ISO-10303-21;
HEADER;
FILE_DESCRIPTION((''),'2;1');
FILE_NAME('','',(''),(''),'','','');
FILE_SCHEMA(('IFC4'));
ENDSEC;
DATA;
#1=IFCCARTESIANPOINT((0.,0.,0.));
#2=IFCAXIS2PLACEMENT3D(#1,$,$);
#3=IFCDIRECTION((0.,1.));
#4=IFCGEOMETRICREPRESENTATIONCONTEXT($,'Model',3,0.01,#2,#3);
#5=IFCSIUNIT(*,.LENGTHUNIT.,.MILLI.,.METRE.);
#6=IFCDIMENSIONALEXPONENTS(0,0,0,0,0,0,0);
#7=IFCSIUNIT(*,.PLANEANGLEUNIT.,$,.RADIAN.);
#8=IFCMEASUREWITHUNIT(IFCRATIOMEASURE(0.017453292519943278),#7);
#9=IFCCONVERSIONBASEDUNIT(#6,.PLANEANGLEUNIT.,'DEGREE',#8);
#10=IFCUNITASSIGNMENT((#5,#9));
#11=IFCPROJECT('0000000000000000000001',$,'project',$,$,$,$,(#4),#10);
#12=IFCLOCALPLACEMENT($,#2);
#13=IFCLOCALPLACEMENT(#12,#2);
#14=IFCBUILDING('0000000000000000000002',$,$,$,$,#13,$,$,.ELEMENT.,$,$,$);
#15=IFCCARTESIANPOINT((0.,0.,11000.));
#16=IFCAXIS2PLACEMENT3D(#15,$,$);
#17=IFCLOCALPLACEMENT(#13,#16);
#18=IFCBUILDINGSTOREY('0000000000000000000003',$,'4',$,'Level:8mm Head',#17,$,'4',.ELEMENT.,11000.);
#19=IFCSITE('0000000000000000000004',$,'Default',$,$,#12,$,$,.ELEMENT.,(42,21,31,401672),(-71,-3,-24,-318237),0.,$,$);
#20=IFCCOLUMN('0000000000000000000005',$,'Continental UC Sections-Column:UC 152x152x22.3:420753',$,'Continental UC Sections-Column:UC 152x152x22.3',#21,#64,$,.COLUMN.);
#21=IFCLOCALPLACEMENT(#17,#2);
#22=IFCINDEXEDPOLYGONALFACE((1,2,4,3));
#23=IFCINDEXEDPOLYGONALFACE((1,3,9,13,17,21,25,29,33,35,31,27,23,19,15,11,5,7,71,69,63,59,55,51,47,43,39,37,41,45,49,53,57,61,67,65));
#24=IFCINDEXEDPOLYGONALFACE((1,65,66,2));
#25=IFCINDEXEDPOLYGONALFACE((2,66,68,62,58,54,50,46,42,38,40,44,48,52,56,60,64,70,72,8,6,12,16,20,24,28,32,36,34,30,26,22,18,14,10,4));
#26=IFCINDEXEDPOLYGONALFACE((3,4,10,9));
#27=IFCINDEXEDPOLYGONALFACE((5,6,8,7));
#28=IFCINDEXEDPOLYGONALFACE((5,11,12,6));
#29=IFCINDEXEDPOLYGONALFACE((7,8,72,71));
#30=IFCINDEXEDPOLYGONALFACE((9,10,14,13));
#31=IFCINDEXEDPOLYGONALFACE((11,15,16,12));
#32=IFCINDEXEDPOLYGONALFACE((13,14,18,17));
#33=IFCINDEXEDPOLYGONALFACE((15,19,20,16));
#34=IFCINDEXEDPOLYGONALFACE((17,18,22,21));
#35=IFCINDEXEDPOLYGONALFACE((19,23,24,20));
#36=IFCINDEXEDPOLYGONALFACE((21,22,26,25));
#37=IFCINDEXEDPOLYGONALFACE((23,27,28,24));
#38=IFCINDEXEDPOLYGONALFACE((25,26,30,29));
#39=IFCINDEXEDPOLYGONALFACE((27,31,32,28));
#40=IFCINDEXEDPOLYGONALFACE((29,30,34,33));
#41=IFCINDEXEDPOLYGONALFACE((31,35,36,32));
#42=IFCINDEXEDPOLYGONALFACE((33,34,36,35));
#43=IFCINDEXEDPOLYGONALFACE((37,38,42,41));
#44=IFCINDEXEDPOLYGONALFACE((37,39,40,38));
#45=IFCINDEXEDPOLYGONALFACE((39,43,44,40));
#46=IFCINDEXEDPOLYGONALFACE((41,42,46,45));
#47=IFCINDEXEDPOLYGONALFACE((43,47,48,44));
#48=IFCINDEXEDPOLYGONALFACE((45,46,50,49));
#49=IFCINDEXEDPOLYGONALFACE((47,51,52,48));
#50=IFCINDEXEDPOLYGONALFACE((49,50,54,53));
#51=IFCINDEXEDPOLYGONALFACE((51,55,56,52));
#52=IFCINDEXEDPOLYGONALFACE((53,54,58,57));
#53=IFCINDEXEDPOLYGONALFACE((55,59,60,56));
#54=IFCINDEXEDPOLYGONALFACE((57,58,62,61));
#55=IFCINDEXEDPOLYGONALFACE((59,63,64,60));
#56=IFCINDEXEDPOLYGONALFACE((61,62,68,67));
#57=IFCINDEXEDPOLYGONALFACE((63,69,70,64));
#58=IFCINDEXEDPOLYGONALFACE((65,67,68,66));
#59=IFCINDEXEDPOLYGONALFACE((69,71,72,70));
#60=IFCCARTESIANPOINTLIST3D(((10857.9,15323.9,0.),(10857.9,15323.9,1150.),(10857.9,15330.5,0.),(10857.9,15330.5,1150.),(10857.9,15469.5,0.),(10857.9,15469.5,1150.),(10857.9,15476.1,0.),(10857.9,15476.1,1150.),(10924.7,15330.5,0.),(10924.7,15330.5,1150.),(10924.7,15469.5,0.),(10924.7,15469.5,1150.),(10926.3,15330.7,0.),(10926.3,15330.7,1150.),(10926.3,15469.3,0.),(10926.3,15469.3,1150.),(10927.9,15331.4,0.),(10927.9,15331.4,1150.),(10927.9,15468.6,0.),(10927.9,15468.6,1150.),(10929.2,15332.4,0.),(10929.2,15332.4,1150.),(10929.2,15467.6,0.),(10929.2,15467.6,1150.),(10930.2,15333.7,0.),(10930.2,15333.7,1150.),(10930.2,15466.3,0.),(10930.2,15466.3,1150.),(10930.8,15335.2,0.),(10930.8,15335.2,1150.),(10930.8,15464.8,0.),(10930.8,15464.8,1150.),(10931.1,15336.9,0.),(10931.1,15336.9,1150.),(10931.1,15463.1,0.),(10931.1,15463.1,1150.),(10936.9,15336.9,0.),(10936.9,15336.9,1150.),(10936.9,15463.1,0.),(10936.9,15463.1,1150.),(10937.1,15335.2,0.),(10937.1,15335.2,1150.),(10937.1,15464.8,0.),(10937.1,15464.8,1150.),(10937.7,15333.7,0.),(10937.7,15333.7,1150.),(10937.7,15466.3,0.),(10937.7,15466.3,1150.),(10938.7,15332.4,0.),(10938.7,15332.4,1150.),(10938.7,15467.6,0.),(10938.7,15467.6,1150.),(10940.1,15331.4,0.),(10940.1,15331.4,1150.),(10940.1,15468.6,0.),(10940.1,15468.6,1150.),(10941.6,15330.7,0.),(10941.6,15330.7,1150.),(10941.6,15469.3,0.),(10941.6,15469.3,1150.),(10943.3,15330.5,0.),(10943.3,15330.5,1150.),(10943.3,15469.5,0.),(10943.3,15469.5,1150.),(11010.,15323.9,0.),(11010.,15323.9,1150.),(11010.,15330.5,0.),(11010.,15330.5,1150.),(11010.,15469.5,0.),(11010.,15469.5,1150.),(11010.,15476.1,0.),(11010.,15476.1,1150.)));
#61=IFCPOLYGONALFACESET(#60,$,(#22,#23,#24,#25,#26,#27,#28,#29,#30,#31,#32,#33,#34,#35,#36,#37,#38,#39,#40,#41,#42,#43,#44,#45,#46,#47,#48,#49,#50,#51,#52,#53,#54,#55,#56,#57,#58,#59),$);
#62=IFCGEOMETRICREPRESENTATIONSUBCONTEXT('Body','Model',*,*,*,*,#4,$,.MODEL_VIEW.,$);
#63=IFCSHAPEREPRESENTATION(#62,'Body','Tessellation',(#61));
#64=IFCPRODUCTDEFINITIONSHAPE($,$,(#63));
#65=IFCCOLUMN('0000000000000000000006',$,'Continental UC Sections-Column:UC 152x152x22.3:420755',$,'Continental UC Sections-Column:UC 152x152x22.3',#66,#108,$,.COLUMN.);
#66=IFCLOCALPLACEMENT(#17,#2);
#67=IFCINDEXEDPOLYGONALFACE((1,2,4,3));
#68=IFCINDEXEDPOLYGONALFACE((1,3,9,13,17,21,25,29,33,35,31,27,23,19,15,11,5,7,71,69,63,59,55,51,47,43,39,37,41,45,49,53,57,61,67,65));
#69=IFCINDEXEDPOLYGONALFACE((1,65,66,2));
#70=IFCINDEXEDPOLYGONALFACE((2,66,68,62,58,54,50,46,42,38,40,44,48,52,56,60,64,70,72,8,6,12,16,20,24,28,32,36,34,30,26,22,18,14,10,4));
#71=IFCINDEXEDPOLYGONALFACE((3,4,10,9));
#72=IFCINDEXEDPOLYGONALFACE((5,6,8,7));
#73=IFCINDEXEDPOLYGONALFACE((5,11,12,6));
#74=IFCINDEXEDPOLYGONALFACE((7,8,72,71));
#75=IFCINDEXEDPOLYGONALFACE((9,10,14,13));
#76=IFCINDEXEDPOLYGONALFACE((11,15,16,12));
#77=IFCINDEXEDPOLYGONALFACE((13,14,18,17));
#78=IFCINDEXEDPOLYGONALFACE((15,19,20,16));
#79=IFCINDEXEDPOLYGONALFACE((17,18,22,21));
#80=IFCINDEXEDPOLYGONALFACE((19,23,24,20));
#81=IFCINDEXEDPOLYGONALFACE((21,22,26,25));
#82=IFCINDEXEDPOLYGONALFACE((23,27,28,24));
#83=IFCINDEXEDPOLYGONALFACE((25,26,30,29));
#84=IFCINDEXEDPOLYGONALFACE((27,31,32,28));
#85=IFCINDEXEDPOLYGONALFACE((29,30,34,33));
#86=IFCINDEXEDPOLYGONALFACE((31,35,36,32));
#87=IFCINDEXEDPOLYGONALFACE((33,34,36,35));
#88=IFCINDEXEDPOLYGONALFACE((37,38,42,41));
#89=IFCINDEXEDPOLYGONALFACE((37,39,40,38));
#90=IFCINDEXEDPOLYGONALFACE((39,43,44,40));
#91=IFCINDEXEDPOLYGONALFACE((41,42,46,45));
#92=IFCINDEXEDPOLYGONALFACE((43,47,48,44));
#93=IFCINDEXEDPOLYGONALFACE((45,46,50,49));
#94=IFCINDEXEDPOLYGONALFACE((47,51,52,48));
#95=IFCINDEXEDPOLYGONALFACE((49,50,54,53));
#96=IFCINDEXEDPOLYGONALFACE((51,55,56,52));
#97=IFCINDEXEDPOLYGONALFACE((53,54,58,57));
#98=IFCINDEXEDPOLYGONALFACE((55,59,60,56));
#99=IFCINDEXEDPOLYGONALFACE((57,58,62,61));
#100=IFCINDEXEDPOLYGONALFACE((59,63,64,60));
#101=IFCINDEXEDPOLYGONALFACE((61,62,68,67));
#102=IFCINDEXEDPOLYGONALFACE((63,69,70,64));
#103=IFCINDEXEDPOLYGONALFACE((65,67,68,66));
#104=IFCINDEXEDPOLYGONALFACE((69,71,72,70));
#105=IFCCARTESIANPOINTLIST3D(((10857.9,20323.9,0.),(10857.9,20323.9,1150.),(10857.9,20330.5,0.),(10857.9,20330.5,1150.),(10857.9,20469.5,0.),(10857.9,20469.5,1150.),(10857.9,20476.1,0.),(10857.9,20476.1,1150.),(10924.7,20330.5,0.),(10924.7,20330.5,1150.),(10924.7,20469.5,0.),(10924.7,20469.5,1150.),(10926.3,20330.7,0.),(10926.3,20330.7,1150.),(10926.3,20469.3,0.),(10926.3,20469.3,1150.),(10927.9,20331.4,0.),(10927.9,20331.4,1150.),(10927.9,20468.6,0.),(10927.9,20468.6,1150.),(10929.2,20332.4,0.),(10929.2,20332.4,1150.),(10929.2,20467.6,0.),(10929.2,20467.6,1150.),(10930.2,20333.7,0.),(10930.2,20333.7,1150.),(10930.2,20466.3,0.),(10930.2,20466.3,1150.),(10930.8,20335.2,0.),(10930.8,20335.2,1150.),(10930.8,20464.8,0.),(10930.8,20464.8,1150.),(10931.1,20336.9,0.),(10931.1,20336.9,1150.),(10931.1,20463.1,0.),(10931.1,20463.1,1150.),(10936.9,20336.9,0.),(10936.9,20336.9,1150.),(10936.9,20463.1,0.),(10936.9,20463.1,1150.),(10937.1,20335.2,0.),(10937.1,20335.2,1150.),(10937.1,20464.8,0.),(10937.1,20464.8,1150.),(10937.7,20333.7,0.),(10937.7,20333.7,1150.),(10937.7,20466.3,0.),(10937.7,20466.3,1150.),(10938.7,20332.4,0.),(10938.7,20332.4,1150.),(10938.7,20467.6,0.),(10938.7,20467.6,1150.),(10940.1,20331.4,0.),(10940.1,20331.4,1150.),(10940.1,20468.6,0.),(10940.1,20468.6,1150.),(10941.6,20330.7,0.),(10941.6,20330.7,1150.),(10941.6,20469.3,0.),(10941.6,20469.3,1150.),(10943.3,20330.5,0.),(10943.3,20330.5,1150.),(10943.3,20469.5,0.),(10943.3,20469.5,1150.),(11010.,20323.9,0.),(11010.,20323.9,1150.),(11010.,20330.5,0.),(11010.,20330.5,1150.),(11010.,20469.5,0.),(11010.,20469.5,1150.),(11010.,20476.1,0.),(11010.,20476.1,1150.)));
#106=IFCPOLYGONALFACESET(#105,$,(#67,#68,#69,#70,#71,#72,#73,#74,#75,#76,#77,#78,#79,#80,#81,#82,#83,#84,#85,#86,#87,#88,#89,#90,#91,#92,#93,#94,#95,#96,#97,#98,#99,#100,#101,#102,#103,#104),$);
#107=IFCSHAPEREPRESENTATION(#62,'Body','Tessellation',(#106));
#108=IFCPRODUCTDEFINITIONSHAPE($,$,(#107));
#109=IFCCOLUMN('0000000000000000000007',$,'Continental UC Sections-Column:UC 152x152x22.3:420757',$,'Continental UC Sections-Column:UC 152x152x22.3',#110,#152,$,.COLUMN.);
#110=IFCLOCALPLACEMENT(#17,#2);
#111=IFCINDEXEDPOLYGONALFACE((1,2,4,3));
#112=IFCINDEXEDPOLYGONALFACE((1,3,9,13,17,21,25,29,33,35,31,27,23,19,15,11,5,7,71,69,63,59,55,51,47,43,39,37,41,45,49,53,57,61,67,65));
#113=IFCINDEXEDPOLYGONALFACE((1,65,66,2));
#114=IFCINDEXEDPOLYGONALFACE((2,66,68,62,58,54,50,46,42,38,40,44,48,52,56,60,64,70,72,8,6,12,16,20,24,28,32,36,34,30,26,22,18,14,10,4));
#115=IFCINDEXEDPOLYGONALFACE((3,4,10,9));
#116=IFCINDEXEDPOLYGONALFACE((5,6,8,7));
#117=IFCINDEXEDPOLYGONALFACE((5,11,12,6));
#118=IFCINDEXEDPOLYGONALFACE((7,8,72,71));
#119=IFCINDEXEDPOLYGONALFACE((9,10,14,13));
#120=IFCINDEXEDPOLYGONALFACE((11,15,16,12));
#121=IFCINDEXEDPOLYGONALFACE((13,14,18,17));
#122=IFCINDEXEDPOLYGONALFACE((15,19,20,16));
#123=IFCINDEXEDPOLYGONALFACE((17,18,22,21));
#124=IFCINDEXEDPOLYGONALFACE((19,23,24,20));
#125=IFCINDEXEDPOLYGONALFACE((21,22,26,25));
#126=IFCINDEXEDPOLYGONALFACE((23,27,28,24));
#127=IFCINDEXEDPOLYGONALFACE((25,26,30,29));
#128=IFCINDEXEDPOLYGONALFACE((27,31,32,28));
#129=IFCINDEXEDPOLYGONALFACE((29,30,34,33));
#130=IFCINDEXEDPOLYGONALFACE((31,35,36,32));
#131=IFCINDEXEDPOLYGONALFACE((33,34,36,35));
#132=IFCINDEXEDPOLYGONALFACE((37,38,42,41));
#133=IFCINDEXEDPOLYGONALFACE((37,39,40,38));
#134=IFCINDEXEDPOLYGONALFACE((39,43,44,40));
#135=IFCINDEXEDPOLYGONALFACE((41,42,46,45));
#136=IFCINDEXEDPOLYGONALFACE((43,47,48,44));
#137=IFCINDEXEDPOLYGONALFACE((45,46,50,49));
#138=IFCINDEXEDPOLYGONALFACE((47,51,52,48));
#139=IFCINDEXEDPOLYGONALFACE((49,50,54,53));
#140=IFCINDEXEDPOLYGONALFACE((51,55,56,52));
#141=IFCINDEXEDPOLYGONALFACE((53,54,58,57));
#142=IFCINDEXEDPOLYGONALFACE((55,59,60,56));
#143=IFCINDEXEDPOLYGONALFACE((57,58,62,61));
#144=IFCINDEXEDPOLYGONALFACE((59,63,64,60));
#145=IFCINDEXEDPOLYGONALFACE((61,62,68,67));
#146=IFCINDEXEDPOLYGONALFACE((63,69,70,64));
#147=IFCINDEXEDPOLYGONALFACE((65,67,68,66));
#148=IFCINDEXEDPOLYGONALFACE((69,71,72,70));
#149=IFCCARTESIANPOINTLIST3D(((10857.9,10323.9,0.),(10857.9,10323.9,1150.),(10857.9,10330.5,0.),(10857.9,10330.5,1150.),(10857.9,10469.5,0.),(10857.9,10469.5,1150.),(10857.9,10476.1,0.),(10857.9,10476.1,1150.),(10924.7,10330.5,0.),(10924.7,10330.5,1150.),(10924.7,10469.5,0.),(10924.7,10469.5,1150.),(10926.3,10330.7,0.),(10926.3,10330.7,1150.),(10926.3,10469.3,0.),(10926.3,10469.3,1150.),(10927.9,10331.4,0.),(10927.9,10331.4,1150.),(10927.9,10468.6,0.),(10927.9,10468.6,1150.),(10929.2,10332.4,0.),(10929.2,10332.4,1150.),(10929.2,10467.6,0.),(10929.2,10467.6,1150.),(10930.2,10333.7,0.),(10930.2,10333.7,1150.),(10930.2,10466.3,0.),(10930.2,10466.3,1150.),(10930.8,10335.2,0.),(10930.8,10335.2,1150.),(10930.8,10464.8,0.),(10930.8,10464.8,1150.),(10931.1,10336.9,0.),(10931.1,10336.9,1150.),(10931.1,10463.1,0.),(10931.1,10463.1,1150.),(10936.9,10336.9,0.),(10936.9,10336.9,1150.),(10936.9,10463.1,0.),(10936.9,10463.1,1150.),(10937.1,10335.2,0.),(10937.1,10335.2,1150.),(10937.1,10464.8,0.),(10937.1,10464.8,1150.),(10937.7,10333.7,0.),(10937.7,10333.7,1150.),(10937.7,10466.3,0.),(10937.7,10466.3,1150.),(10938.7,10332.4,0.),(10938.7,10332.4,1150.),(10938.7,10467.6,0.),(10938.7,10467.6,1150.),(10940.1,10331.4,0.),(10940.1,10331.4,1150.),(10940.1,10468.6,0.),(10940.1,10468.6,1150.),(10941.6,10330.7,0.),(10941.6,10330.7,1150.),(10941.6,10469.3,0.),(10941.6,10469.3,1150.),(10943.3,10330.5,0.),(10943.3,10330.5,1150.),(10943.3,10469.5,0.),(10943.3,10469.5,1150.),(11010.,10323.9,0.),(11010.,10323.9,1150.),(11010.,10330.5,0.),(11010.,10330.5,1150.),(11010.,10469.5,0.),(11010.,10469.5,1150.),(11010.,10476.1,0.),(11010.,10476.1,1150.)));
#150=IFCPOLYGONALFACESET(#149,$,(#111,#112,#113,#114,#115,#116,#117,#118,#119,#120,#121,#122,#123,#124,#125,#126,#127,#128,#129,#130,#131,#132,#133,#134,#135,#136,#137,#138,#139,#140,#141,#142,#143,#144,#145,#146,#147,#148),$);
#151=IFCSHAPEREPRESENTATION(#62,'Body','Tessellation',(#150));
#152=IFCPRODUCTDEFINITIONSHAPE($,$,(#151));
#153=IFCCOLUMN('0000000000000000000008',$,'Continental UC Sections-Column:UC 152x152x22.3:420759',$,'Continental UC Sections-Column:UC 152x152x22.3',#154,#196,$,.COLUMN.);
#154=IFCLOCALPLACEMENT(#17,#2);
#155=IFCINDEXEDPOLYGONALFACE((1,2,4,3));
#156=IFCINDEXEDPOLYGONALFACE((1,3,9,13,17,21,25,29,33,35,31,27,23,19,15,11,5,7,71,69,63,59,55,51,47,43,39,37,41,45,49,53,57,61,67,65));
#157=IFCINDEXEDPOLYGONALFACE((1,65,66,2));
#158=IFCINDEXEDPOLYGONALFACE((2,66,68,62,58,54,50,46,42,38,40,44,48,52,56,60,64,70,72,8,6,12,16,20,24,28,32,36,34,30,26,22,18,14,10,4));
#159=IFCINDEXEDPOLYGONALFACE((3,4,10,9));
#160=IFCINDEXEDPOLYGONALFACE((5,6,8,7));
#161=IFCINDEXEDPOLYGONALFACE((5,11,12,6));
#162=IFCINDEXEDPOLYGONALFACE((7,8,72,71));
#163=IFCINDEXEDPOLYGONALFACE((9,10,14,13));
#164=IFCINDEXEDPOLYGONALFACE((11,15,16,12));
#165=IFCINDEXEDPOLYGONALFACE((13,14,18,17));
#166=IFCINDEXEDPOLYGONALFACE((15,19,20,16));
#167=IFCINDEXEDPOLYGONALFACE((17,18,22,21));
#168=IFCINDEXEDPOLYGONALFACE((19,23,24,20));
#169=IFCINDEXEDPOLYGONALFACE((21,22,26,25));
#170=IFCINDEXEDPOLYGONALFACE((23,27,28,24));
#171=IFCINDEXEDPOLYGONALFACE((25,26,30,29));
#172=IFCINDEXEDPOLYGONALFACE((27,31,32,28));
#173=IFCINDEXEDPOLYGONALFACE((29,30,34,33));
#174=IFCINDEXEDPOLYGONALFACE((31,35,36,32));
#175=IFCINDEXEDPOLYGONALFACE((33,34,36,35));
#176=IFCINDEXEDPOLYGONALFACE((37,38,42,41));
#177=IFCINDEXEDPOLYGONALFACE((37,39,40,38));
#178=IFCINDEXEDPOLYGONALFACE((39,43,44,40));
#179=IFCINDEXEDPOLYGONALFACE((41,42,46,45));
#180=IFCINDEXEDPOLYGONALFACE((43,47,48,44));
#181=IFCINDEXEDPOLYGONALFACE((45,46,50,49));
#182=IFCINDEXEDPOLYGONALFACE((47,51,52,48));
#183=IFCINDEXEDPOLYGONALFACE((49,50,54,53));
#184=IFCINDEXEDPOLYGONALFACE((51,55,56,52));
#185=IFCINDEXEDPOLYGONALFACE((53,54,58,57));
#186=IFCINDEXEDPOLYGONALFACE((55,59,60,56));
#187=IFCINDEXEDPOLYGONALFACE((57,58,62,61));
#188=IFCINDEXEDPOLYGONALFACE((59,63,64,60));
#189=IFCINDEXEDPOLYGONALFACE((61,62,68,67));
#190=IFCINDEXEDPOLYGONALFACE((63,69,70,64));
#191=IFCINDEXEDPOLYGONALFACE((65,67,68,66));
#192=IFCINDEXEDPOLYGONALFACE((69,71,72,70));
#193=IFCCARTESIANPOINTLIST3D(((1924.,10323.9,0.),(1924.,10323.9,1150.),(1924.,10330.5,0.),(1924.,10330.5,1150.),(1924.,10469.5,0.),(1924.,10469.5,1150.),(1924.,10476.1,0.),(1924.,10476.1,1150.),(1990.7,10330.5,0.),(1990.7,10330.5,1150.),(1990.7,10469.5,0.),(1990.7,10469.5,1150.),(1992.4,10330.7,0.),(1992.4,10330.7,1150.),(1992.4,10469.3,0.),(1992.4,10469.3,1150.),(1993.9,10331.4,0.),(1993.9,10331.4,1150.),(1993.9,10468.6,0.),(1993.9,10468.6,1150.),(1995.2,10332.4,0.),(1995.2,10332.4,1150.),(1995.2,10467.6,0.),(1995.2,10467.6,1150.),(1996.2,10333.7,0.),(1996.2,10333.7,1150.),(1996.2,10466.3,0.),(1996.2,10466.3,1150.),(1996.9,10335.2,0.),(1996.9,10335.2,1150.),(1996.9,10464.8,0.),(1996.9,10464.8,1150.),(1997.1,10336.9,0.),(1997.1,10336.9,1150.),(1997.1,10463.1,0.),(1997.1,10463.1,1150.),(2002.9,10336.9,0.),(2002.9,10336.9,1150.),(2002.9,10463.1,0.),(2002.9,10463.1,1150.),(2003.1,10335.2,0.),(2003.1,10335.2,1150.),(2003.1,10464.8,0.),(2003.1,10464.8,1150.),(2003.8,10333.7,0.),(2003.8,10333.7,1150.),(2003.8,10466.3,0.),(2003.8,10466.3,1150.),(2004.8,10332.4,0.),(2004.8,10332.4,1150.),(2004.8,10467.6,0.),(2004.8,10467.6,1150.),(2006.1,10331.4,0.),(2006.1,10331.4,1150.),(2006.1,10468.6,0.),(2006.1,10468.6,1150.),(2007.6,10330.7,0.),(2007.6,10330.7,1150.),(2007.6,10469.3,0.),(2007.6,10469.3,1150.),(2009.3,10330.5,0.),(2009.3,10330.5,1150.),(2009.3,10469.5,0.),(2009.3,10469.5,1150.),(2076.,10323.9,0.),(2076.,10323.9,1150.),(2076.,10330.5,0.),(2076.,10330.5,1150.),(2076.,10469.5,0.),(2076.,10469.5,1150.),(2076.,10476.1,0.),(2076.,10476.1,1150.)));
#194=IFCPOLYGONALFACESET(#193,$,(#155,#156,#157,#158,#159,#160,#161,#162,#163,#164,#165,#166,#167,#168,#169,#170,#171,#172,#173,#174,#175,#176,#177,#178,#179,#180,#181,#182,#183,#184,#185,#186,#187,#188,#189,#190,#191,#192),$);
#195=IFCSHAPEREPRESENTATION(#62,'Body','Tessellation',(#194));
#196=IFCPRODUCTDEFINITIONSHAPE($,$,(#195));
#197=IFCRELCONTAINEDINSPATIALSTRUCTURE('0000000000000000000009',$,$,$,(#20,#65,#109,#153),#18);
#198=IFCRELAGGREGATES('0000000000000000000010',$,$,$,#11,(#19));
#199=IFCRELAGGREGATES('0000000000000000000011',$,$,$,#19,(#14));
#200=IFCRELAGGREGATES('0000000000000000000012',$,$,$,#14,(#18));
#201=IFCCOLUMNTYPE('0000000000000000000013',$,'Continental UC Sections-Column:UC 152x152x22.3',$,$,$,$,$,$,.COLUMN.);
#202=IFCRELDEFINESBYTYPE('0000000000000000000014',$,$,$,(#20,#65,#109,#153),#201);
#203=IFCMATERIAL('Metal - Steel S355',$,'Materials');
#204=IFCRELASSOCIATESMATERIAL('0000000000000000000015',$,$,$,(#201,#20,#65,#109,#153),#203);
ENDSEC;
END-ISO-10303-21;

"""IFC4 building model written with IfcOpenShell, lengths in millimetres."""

from ifc_helpers import new_model, entity, si_unit, converted_unit, direction, frame, origin, place, context, subcontext, project, spatial, line, arc, indexed_curve, outline, extrude, source, transform, mapped, material, type_object, type_shapes, element, save


model = new_model("IFC4")

# Units and contexts
model_context = context("Model", 3, precision=0.01, world=origin(), true_north=direction((0.0, 1.0)))
body_context = subcontext(model_context, "Body", "Model", "MODEL_VIEW")
ifc_project = project(units=[si_unit("LENGTHUNIT", "METRE", prefix="MILLI"), converted_unit("PLANEANGLEUNIT", "DEGREE", entity("IfcRatioMeasure", 0.017453292519943278), si_unit("PLANEANGLEUNIT", "RADIAN"), dimensions=[0, 0, 0, 0, 0, 0, 0])], contexts=[model_context])

# Site, building, storey
site_placement = place(None, origin())
site = spatial("IfcSite", under=ifc_project, at=site_placement, Name="Default", CompositionType="ELEMENT", RefLatitude=(42, 21, 31, 401672), RefLongitude=(-71, -3, -24, -318237), RefElevation=0.0)
building_placement = place(site_placement, origin())
building = spatial("IfcBuilding", under=site, at=building_placement, CompositionType="ELEMENT")
storey_placement = place(building_placement, frame((0.0, 0.0, 11000.0)))
storey = spatial("IfcBuildingStorey", under=building, at=storey_placement, Name="4", ObjectType="Level:8mm Head", LongName="4", CompositionType="ELEMENT", Elevation=11000.0)

# Columns
ifc_material_1 = material(Name="Metal - Steel S355", Category="Materials")
column_type_1 = type_object("IfcColumnType", Name="Continental UC Sections-Column:UC 152x152x22.3", PredefinedType="COLUMN", material=ifc_material_1)
shared_shape_1 = source(origin(), body_context, "Body", "SweptSolid", [
    extrude(outline(indexed_curve([(69.5, -76.0), (76.1, -76.0), (76.1, 76.0), (69.5, 76.0), (69.5, 9.3), (67.6, 4.8), (63.1, 2.9), (-63.1, 2.9), (-67.6, 4.8), (-69.5, 9.3), (-69.5, 76.0), (-76.1, 76.0), (-76.1, -76.0), (-69.5, -76.0), (-69.5, -9.3), (-67.6, -4.8), (-63.1, -2.9), (63.1, -2.9), (67.6, -4.8), (69.5, -9.3)], segments=[line(1, 2, 3, 4, 5), arc(5, 6, 7), line(7, 8), arc(8, 9, 10), line(10, 11, 12, 13, 14, 15), arc(15, 16, 17), line(17, 18), arc(18, 19, 20), line(20, 1)], self_intersect=False)), frame((0.0, 0.0, 11000.0), z_axis=(0.0, 0.0, 1.0), x_axis=(0.0, -1.0, 0.0)), (0.0, 0.0, 1.0), 1150.0),
])
type_shapes(column_type_1, [shared_shape_1])
for number, where, name in (
    (1, (10934.0, 15400.0, -11000.0), "Continental UC Sections-Column:UC 152x152x22.3:420753"),
    (2, (10934.0, 20400.0, -11000.0), "Continental UC Sections-Column:UC 152x152x22.3:420755"),
    (3, (10934.0, 10400.0, -11000.0), "Continental UC Sections-Column:UC 152x152x22.3:420757"),
    (4, (2000.0, 10400.0, -11000.0), "Continental UC Sections-Column:UC 152x152x22.3:420759"),
):
    element("IfcColumn", number, at=place(storey_placement, frame(where)), inside=storey, type_object=column_type_1, material=ifc_material_1, Name=name, ObjectType="Continental UC Sections-Column:UC 152x152x22.3", PredefinedType="COLUMN", context=body_context, shape_type="MappedRepresentation", body=[
        mapped(shared_shape_1, transform((0.0, 0.0, 0.0), scale=1.0)),
    ])

save(model, "model.ifc")
